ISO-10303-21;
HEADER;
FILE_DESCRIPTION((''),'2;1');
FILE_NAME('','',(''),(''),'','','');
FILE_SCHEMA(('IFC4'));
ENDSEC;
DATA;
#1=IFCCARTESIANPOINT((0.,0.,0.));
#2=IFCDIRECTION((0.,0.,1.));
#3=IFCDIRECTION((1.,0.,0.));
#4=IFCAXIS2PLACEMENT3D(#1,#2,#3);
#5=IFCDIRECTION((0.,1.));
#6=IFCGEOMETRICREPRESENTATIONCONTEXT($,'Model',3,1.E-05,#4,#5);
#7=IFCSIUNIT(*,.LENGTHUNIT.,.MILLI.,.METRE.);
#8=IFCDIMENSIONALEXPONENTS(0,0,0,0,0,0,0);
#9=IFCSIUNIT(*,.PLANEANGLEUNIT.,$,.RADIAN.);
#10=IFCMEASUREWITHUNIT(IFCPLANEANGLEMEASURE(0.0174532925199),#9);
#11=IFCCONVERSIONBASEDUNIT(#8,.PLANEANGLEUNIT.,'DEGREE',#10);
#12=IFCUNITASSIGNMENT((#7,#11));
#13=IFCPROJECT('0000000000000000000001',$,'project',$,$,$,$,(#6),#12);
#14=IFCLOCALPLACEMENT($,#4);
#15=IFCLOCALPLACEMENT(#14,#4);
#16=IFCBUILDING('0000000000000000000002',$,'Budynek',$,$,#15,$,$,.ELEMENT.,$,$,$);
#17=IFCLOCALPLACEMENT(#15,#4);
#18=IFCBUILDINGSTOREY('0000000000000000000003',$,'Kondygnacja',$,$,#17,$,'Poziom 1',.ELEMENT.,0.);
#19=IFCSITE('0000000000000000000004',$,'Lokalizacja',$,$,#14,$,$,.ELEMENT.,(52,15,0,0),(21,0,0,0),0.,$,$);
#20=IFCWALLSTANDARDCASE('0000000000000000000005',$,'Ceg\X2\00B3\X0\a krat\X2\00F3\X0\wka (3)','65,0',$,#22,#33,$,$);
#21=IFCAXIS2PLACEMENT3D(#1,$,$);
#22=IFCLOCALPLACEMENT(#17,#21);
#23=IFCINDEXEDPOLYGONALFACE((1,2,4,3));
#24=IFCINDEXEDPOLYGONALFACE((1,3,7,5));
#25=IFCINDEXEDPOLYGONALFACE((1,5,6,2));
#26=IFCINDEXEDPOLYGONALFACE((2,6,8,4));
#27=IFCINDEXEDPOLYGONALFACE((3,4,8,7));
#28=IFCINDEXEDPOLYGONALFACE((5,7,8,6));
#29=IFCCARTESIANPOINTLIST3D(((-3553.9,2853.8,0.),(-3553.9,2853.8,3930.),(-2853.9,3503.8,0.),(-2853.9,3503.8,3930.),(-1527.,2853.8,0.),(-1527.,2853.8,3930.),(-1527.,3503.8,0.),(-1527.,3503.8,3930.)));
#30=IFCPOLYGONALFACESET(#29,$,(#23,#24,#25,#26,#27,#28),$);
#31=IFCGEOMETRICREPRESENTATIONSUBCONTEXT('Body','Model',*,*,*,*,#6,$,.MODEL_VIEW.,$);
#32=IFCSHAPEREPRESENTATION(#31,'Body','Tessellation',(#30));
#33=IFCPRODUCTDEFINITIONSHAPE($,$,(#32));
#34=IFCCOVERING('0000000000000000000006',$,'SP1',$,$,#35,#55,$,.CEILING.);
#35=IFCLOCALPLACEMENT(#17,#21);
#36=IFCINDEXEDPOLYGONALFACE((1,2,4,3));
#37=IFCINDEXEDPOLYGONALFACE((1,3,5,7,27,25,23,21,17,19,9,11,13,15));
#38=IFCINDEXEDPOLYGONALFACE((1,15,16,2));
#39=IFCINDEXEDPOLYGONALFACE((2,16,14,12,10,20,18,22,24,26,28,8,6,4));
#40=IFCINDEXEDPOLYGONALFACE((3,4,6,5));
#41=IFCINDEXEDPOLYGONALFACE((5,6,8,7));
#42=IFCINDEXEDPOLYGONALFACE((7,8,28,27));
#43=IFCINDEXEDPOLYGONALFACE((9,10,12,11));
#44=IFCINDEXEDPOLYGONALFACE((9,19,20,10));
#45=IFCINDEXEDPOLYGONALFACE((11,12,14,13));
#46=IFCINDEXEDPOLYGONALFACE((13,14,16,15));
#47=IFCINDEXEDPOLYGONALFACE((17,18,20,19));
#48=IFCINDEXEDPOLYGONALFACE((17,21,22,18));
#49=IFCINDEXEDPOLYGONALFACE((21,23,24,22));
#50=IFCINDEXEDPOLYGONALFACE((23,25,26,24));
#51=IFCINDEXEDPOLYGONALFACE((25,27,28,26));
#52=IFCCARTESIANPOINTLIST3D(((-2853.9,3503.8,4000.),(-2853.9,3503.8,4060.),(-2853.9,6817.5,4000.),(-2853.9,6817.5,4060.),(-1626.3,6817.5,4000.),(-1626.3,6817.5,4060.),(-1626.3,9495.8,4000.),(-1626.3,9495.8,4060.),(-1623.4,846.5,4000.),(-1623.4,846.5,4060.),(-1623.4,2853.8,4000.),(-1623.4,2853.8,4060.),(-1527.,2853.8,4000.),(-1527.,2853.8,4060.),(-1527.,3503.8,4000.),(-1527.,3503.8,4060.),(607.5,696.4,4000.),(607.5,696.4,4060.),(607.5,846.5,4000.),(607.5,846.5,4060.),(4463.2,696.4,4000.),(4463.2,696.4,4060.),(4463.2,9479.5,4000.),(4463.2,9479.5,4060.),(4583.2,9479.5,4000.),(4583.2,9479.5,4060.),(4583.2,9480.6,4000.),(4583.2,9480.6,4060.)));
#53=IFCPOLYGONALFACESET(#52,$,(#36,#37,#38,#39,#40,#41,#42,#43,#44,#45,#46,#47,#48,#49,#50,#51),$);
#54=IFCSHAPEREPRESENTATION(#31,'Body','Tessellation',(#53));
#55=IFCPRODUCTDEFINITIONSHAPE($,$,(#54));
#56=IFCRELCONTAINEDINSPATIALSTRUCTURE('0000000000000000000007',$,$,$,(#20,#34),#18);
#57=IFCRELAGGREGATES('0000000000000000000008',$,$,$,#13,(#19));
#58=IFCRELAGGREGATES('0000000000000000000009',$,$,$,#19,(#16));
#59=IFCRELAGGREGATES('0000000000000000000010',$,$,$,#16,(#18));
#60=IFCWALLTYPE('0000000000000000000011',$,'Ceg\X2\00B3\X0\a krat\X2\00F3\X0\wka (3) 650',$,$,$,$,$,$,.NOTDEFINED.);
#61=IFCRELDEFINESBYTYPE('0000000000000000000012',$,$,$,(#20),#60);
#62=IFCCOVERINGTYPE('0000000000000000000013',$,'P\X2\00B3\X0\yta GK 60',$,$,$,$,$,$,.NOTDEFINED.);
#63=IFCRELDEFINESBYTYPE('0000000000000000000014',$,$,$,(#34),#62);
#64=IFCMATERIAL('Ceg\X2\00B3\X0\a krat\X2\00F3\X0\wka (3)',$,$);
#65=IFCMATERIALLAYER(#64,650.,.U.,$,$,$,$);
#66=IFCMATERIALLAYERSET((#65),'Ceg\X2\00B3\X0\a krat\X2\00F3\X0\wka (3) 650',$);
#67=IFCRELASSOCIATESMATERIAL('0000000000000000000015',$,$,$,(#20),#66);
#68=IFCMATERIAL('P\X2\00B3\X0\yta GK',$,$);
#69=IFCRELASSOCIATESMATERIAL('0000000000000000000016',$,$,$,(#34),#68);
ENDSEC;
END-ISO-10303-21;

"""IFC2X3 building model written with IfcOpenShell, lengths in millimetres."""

from ifc_helpers import new_model, entity, si_unit, converted_unit, direction, frame, origin_with_axes, place, context, subcontext, project, spatial, polyline, outline, extrude, material, layer, layer_set, layer_usage, type_object, element, save


model = new_model("IFC2X3")

# Units and contexts
model_context = context("Model", 3, precision=1e-05, world=origin_with_axes(), true_north=direction((0.0, 1.0)))
body_context = subcontext(model_context, "Body", "Model", "MODEL_VIEW")
ifc_project = project(units=[si_unit("LENGTHUNIT", "METRE", prefix="MILLI"), converted_unit("PLANEANGLEUNIT", "DEGREE", entity("IfcPlaneAngleMeasure", 0.0174532925199), si_unit("PLANEANGLEUNIT", "RADIAN"), dimensions=[0, 0, 0, 0, 0, 0, 0])], contexts=[model_context])

# Site, building, storey
site_placement = place(None, origin_with_axes())
site = spatial("IfcSite", under=ifc_project, at=site_placement, Name="Lokalizacja", CompositionType="ELEMENT", RefLatitude=(52, 15, 0, 0), RefLongitude=(21, 0, 0, 0), RefElevation=0.0)
building_placement = place(site_placement, origin_with_axes())
building = spatial("IfcBuilding", under=site, at=building_placement, Name="Budynek", CompositionType="ELEMENT")
storey_placement = place(building_placement, origin_with_axes())
storey = spatial("IfcBuildingStorey", under=building, at=storey_placement, Name="Kondygnacja", LongName="Poziom 1", CompositionType="ELEMENT", Elevation=0.0)

# Shared definitions
ifc_material_1 = material(Name="Ceg³a kratówka (3)")

# Wall
ifc_layer_1 = layer(ifc_material_1, 650.0, ventilated="UNKNOWN")
ifc_layer_set_1 = layer_set([ifc_layer_1], Name="Ceg³a kratówka (3) 650")
ifc_layer_usage_1 = layer_usage(ifc_layer_set_1, "AXIS2", "NEGATIVE", 0.0)
wall_type_1 = type_object("IfcWallType", Name="Ceg³a kratówka (3) 650", PredefinedType="NOTDEFINED")
wall_1_placement = place(storey_placement, frame((-2853.9, 3503.8, 0.0), z_axis=(0.0, 0.0, 1.0), x_axis=(1.0, 0.0, 0.0)))
element("IfcWallStandardCase", 1, at=wall_1_placement, inside=storey, type_object=wall_type_1, material=ifc_layer_usage_1, Name="Ceg³a kratówka (3)", Description="65,0", context=body_context, shape_type="SweptSolid", body=[
    extrude(outline(polyline([(-700.0, -650.0), (1326.9, -650.0), (1326.9, 0.0), (0.0, 0.0), (-700.0, -650.0)])), origin_with_axes(), (0.0, 0.0, 1.0), 3930.0),
])

# Covering
ifc_material_2 = material(Name="P³yta GK")
covering_type = type_object("IfcCoveringType", Name="P³yta GK 60", PredefinedType="NOTDEFINED")
covering_placement = place(storey_placement, frame((-2853.9, 3503.8, 4060.0), z_axis=(0.0, 0.0, 1.0), x_axis=(1.0, 0.0, 0.0)))
element("IfcCovering", 2, at=covering_placement, inside=storey, type_object=covering_type, material=ifc_material_2, Name="SP1", PredefinedType="CEILING", context=body_context, shape_type="SweptSolid", body=[
    extrude(outline(polyline([(0.0, 0.0), (1326.9, 0.0), (1326.9, -650.0), (1230.5, -650.0), (1230.5, -2657.3), (3461.4, -2657.3), (3461.4, -2807.4), (7317.1, -2807.4), (7317.1, 5975.7), (7437.1, 5975.7), (7437.1, 5976.8), (1227.6, 5992.0), (1227.6, 3313.7), (0.0, 3313.7), (0.0, 0.0)])), frame((0.0, 0.0, -60.0), z_axis=(0.0, 0.0, 1.0), x_axis=(1.0, 0.0, 0.0)), (0.0, 0.0, 1.0), 60.0),
])

save(model, "model.ifc")
